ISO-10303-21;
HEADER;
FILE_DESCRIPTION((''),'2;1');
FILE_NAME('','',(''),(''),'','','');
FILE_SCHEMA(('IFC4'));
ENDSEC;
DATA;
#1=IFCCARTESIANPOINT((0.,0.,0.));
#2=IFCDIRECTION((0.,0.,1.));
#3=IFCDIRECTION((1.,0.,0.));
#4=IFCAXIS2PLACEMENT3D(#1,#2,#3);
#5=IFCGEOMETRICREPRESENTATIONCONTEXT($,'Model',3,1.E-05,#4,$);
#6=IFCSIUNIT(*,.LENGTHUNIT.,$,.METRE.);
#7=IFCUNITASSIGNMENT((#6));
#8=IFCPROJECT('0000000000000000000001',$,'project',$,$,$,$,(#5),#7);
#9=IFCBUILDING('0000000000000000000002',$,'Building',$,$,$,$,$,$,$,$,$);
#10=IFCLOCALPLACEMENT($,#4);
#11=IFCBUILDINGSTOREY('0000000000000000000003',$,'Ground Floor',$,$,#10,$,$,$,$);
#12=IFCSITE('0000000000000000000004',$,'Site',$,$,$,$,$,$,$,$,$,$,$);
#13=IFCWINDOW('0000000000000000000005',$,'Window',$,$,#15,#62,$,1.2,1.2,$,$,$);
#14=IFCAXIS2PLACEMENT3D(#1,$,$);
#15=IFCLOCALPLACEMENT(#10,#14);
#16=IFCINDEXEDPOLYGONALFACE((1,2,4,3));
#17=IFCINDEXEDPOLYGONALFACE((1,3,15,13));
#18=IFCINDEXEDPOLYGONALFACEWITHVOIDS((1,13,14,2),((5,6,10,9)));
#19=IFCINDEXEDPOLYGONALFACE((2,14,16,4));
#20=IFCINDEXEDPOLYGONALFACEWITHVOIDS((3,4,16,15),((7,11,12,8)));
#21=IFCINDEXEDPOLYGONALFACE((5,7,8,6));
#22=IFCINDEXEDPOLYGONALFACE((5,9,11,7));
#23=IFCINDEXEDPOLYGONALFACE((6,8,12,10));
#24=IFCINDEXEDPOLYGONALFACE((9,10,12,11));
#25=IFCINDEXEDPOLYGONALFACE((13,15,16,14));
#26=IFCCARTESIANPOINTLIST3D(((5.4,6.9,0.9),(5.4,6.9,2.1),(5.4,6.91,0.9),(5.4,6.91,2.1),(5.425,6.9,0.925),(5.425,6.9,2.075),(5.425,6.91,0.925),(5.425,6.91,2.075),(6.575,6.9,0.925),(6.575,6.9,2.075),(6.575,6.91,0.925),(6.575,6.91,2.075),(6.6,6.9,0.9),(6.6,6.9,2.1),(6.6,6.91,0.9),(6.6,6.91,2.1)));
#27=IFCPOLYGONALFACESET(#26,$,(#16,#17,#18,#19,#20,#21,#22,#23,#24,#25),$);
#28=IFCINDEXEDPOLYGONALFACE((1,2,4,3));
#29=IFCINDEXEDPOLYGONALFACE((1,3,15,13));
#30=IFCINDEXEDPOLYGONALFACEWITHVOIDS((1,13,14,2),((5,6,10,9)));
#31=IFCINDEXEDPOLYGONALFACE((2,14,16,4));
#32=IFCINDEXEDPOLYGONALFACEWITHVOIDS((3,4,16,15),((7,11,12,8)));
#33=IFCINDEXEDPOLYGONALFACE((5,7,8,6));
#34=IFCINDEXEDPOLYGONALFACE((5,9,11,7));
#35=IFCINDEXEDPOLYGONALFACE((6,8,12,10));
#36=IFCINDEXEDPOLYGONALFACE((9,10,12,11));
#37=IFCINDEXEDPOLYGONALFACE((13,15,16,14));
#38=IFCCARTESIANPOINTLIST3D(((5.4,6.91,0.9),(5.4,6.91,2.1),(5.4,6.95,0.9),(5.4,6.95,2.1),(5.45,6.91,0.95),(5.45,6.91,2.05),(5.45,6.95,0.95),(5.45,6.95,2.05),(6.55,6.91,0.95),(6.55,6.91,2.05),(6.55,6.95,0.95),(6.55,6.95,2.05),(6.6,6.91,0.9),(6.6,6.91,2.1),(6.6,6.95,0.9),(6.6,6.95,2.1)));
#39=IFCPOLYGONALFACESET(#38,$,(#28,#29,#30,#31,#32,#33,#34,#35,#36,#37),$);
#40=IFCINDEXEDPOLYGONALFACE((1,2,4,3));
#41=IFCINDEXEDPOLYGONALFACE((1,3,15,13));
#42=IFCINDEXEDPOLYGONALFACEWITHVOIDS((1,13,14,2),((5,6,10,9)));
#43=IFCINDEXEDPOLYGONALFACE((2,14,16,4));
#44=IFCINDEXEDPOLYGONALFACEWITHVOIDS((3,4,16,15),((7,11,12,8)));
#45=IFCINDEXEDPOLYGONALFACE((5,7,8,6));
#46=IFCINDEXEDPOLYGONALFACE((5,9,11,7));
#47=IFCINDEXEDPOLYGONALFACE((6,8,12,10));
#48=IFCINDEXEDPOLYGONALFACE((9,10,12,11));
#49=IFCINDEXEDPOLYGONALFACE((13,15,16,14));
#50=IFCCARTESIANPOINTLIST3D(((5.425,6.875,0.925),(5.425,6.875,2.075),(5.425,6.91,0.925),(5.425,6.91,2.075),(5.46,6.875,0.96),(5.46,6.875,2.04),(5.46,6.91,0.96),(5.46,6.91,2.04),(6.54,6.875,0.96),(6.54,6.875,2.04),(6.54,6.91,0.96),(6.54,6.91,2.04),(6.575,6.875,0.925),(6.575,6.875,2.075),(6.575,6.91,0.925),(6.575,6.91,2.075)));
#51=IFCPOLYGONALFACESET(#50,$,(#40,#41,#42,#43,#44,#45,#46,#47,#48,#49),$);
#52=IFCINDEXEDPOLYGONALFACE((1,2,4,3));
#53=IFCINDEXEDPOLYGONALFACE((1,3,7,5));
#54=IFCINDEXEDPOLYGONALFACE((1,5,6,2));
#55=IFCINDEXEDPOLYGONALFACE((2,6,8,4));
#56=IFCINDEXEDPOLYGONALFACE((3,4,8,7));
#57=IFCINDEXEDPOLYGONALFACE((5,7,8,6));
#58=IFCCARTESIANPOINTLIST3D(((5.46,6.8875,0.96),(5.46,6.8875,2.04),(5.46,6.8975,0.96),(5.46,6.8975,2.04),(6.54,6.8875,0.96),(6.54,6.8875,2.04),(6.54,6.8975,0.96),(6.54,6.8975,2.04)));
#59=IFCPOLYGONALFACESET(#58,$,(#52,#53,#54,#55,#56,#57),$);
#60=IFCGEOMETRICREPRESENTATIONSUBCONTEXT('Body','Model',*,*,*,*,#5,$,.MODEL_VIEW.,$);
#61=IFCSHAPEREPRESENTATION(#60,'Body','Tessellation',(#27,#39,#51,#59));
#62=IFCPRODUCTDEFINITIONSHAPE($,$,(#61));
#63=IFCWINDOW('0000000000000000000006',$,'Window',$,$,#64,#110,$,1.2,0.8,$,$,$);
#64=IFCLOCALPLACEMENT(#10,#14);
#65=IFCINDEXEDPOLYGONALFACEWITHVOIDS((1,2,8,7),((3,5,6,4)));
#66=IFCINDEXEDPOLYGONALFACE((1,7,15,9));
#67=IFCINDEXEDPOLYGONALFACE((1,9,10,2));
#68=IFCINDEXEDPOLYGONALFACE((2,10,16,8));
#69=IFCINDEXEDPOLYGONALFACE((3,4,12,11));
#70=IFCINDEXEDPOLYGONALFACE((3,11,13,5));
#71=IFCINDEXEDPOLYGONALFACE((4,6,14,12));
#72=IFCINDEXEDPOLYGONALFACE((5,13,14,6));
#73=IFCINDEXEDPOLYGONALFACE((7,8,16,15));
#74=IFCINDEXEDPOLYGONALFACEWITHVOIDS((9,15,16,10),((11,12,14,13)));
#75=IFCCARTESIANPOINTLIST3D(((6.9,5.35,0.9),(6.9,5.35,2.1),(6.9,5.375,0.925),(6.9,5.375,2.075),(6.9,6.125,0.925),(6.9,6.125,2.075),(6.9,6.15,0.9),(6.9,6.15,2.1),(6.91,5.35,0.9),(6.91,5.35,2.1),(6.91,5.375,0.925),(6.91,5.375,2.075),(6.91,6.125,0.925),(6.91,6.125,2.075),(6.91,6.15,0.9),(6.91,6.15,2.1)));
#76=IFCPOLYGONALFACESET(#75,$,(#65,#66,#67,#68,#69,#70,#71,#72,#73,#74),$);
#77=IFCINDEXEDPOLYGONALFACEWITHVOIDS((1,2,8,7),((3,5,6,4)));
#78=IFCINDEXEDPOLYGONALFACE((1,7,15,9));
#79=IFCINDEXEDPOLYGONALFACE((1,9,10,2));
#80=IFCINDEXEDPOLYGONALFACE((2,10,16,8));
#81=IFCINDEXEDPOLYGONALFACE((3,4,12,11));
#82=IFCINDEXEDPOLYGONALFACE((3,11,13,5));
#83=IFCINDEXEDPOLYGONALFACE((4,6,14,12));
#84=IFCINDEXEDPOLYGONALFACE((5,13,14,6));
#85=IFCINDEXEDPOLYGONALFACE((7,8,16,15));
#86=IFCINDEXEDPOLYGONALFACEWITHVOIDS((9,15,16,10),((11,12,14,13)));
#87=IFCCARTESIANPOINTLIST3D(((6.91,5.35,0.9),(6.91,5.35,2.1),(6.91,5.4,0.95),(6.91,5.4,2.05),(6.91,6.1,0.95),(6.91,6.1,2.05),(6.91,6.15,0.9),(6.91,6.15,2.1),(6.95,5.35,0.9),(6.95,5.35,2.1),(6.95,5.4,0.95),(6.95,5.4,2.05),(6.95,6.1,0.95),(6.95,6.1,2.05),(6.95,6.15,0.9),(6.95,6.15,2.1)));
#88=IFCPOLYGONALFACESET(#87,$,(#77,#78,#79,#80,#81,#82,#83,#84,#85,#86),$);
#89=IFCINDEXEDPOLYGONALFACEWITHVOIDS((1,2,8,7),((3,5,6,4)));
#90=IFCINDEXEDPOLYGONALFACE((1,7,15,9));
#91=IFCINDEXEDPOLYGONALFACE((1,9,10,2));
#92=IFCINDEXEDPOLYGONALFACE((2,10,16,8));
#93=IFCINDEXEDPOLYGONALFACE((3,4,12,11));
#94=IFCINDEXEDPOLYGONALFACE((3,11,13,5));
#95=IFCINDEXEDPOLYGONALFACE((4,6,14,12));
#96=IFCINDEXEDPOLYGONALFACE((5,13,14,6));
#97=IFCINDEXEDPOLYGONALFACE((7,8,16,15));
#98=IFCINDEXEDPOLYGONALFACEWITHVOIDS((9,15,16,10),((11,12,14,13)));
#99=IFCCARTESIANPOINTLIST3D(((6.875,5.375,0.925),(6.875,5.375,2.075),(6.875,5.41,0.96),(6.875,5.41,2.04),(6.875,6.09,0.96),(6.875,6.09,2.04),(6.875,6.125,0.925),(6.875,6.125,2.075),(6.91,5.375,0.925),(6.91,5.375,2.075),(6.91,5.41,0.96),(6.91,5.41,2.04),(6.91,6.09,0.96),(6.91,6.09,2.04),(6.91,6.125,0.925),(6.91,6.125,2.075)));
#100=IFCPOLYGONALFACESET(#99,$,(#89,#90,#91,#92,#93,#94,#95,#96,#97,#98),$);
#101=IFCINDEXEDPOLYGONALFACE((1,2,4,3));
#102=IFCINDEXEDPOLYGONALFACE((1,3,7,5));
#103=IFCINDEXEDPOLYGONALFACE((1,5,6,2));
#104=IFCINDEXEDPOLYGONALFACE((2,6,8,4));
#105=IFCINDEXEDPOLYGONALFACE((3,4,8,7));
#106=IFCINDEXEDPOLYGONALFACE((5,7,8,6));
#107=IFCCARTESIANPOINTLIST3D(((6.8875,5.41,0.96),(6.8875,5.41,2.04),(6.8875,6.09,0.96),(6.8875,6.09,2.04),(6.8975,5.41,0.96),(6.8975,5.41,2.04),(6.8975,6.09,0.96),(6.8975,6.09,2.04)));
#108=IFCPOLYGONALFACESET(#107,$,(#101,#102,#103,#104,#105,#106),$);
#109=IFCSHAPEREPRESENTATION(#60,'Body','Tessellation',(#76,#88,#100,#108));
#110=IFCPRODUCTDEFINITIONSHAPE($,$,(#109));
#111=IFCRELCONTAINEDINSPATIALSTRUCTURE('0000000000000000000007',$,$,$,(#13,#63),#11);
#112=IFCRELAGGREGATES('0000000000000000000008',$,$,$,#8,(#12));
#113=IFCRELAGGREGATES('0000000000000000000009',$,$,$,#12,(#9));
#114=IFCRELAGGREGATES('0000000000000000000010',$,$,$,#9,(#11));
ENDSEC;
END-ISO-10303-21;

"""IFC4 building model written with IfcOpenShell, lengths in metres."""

from ifc_helpers import new_model, si_unit, frame, origin_with_axes, place, context, subcontext, project, spatial, line, indexed_curve, outline, extrude, element, save


model = new_model("IFC4")

# Units and contexts
model_context = context("Model", 3, precision=1e-05, world=origin_with_axes())
body_context = subcontext(model_context, "Body", "Model", "MODEL_VIEW")
ifc_project = project(units=[si_unit("LENGTHUNIT", "METRE")], contexts=[model_context])

# Site, building, storey
site = spatial("IfcSite", under=ifc_project, Name="Site")
building = spatial("IfcBuilding", under=site, Name="Building")
storey_placement = place(None, origin_with_axes())
storey = spatial("IfcBuildingStorey", under=building, at=storey_placement, Name="Ground Floor")

# Windows
window_1_placement = place(storey_placement, frame((6.6, 7.0, 0.9), z_axis=(0.0, 0.0, 1.0), x_axis=(-1.0, 0.0, 0.0)))
element("IfcWindow", 1, at=window_1_placement, inside=storey, Name="Window", OverallHeight=1.2, OverallWidth=1.2, context=body_context, shape_type="SweptSolid", body=[
    extrude(outline(indexed_curve([(0.0, 0.0), (1.2, 0.0), (1.2, 1.2), (0.0, 1.2)], segments=[line(1, 2, 3, 4, 1)]), holes=[indexed_curve([(0.025, 0.025), (1.175, 0.025), (1.175, 1.175), (0.025, 1.175)], segments=[line(1, 2, 3, 4, 1)])]), frame((0.0, 0.09, 0.0), z_axis=(0.0, -1.0, 0.0), x_axis=(1.0, 0.0, 0.0)), (0.0, 0.0, -1.0), 0.01),
    extrude(outline(indexed_curve([(0.0, 0.0), (1.2, 0.0), (1.2, 1.2), (0.0, 1.2)], segments=[line(1, 2, 3, 4, 1)]), holes=[indexed_curve([(0.05, 0.05), (1.15, 0.05), (1.15, 1.15), (0.05, 1.15)], segments=[line(1, 2, 3, 4, 1)])]), frame((0.0, 0.05, 0.0), z_axis=(0.0, -1.0, 0.0), x_axis=(1.0, 0.0, 0.0)), (0.0, 0.0, -1.0), 0.04),
    extrude(outline(indexed_curve([(0.0, 0.0), (1.15, 0.0), (1.15, 1.15), (0.0, 1.15)], segments=[line(1, 2, 3, 4, 1)]), holes=[indexed_curve([(0.035, 0.035), (1.115, 0.035), (1.115, 1.115), (0.035, 1.115)], segments=[line(1, 2, 3, 4, 1)])]), frame((0.025, 0.09, 0.025), z_axis=(0.0, -1.0, 0.0), x_axis=(1.0, 0.0, 0.0)), (0.0, 0.0, -1.0), 0.035),
    extrude(outline(indexed_curve([(0.035, 0.035), (1.115, 0.035), (1.115, 1.115), (0.035, 1.115)], segments=[line(1, 2, 3, 4, 1)])), frame((0.025, 0.1025, 0.025), z_axis=(0.0, -1.0, 0.0), x_axis=(1.0, 0.0, 0.0)), (0.0, 0.0, -1.0), 0.01),
])
window_2_placement = place(storey_placement, frame((7.0, 5.35, 0.9), z_axis=(0.0, 0.0, 1.0), x_axis=(0.0, 1.0, 0.0)))
element("IfcWindow", 2, at=window_2_placement, inside=storey, Name="Window", OverallHeight=1.2, OverallWidth=0.8, context=body_context, shape_type="SweptSolid", body=[
    extrude(outline(indexed_curve([(0.0, 0.0), (0.8, 0.0), (0.8, 1.2), (0.0, 1.2)], segments=[line(1, 2, 3, 4, 1)]), holes=[indexed_curve([(0.025, 0.025), (0.775, 0.025), (0.775, 1.175), (0.025, 1.175)], segments=[line(1, 2, 3, 4, 1)])]), frame((0.0, 0.09, 0.0), z_axis=(0.0, -1.0, 0.0), x_axis=(1.0, 0.0, 0.0)), (0.0, 0.0, -1.0), 0.01),
    extrude(outline(indexed_curve([(0.0, 0.0), (0.8, 0.0), (0.8, 1.2), (0.0, 1.2)], segments=[line(1, 2, 3, 4, 1)]), holes=[indexed_curve([(0.05, 0.05), (0.75, 0.05), (0.75, 1.15), (0.05, 1.15)], segments=[line(1, 2, 3, 4, 1)])]), frame((0.0, 0.05, 0.0), z_axis=(0.0, -1.0, 0.0), x_axis=(1.0, 0.0, 0.0)), (0.0, 0.0, -1.0), 0.04),
    extrude(outline(indexed_curve([(0.0, 0.0), (0.75, 0.0), (0.75, 1.15), (0.0, 1.15)], segments=[line(1, 2, 3, 4, 1)]), holes=[indexed_curve([(0.035, 0.035), (0.715, 0.035), (0.715, 1.115), (0.035, 1.115)], segments=[line(1, 2, 3, 4, 1)])]), frame((0.025, 0.09, 0.025), z_axis=(0.0, -1.0, 0.0), x_axis=(1.0, 0.0, 0.0)), (0.0, 0.0, -1.0), 0.035),
    extrude(outline(indexed_curve([(0.035, 0.035), (0.715, 0.035), (0.715, 1.115), (0.035, 1.115)], segments=[line(1, 2, 3, 4, 1)])), frame((0.025, 0.1025, 0.025), z_axis=(0.0, -1.0, 0.0), x_axis=(1.0, 0.0, 0.0)), (0.0, 0.0, -1.0), 0.01),
])

save(model, "model.ifc")
